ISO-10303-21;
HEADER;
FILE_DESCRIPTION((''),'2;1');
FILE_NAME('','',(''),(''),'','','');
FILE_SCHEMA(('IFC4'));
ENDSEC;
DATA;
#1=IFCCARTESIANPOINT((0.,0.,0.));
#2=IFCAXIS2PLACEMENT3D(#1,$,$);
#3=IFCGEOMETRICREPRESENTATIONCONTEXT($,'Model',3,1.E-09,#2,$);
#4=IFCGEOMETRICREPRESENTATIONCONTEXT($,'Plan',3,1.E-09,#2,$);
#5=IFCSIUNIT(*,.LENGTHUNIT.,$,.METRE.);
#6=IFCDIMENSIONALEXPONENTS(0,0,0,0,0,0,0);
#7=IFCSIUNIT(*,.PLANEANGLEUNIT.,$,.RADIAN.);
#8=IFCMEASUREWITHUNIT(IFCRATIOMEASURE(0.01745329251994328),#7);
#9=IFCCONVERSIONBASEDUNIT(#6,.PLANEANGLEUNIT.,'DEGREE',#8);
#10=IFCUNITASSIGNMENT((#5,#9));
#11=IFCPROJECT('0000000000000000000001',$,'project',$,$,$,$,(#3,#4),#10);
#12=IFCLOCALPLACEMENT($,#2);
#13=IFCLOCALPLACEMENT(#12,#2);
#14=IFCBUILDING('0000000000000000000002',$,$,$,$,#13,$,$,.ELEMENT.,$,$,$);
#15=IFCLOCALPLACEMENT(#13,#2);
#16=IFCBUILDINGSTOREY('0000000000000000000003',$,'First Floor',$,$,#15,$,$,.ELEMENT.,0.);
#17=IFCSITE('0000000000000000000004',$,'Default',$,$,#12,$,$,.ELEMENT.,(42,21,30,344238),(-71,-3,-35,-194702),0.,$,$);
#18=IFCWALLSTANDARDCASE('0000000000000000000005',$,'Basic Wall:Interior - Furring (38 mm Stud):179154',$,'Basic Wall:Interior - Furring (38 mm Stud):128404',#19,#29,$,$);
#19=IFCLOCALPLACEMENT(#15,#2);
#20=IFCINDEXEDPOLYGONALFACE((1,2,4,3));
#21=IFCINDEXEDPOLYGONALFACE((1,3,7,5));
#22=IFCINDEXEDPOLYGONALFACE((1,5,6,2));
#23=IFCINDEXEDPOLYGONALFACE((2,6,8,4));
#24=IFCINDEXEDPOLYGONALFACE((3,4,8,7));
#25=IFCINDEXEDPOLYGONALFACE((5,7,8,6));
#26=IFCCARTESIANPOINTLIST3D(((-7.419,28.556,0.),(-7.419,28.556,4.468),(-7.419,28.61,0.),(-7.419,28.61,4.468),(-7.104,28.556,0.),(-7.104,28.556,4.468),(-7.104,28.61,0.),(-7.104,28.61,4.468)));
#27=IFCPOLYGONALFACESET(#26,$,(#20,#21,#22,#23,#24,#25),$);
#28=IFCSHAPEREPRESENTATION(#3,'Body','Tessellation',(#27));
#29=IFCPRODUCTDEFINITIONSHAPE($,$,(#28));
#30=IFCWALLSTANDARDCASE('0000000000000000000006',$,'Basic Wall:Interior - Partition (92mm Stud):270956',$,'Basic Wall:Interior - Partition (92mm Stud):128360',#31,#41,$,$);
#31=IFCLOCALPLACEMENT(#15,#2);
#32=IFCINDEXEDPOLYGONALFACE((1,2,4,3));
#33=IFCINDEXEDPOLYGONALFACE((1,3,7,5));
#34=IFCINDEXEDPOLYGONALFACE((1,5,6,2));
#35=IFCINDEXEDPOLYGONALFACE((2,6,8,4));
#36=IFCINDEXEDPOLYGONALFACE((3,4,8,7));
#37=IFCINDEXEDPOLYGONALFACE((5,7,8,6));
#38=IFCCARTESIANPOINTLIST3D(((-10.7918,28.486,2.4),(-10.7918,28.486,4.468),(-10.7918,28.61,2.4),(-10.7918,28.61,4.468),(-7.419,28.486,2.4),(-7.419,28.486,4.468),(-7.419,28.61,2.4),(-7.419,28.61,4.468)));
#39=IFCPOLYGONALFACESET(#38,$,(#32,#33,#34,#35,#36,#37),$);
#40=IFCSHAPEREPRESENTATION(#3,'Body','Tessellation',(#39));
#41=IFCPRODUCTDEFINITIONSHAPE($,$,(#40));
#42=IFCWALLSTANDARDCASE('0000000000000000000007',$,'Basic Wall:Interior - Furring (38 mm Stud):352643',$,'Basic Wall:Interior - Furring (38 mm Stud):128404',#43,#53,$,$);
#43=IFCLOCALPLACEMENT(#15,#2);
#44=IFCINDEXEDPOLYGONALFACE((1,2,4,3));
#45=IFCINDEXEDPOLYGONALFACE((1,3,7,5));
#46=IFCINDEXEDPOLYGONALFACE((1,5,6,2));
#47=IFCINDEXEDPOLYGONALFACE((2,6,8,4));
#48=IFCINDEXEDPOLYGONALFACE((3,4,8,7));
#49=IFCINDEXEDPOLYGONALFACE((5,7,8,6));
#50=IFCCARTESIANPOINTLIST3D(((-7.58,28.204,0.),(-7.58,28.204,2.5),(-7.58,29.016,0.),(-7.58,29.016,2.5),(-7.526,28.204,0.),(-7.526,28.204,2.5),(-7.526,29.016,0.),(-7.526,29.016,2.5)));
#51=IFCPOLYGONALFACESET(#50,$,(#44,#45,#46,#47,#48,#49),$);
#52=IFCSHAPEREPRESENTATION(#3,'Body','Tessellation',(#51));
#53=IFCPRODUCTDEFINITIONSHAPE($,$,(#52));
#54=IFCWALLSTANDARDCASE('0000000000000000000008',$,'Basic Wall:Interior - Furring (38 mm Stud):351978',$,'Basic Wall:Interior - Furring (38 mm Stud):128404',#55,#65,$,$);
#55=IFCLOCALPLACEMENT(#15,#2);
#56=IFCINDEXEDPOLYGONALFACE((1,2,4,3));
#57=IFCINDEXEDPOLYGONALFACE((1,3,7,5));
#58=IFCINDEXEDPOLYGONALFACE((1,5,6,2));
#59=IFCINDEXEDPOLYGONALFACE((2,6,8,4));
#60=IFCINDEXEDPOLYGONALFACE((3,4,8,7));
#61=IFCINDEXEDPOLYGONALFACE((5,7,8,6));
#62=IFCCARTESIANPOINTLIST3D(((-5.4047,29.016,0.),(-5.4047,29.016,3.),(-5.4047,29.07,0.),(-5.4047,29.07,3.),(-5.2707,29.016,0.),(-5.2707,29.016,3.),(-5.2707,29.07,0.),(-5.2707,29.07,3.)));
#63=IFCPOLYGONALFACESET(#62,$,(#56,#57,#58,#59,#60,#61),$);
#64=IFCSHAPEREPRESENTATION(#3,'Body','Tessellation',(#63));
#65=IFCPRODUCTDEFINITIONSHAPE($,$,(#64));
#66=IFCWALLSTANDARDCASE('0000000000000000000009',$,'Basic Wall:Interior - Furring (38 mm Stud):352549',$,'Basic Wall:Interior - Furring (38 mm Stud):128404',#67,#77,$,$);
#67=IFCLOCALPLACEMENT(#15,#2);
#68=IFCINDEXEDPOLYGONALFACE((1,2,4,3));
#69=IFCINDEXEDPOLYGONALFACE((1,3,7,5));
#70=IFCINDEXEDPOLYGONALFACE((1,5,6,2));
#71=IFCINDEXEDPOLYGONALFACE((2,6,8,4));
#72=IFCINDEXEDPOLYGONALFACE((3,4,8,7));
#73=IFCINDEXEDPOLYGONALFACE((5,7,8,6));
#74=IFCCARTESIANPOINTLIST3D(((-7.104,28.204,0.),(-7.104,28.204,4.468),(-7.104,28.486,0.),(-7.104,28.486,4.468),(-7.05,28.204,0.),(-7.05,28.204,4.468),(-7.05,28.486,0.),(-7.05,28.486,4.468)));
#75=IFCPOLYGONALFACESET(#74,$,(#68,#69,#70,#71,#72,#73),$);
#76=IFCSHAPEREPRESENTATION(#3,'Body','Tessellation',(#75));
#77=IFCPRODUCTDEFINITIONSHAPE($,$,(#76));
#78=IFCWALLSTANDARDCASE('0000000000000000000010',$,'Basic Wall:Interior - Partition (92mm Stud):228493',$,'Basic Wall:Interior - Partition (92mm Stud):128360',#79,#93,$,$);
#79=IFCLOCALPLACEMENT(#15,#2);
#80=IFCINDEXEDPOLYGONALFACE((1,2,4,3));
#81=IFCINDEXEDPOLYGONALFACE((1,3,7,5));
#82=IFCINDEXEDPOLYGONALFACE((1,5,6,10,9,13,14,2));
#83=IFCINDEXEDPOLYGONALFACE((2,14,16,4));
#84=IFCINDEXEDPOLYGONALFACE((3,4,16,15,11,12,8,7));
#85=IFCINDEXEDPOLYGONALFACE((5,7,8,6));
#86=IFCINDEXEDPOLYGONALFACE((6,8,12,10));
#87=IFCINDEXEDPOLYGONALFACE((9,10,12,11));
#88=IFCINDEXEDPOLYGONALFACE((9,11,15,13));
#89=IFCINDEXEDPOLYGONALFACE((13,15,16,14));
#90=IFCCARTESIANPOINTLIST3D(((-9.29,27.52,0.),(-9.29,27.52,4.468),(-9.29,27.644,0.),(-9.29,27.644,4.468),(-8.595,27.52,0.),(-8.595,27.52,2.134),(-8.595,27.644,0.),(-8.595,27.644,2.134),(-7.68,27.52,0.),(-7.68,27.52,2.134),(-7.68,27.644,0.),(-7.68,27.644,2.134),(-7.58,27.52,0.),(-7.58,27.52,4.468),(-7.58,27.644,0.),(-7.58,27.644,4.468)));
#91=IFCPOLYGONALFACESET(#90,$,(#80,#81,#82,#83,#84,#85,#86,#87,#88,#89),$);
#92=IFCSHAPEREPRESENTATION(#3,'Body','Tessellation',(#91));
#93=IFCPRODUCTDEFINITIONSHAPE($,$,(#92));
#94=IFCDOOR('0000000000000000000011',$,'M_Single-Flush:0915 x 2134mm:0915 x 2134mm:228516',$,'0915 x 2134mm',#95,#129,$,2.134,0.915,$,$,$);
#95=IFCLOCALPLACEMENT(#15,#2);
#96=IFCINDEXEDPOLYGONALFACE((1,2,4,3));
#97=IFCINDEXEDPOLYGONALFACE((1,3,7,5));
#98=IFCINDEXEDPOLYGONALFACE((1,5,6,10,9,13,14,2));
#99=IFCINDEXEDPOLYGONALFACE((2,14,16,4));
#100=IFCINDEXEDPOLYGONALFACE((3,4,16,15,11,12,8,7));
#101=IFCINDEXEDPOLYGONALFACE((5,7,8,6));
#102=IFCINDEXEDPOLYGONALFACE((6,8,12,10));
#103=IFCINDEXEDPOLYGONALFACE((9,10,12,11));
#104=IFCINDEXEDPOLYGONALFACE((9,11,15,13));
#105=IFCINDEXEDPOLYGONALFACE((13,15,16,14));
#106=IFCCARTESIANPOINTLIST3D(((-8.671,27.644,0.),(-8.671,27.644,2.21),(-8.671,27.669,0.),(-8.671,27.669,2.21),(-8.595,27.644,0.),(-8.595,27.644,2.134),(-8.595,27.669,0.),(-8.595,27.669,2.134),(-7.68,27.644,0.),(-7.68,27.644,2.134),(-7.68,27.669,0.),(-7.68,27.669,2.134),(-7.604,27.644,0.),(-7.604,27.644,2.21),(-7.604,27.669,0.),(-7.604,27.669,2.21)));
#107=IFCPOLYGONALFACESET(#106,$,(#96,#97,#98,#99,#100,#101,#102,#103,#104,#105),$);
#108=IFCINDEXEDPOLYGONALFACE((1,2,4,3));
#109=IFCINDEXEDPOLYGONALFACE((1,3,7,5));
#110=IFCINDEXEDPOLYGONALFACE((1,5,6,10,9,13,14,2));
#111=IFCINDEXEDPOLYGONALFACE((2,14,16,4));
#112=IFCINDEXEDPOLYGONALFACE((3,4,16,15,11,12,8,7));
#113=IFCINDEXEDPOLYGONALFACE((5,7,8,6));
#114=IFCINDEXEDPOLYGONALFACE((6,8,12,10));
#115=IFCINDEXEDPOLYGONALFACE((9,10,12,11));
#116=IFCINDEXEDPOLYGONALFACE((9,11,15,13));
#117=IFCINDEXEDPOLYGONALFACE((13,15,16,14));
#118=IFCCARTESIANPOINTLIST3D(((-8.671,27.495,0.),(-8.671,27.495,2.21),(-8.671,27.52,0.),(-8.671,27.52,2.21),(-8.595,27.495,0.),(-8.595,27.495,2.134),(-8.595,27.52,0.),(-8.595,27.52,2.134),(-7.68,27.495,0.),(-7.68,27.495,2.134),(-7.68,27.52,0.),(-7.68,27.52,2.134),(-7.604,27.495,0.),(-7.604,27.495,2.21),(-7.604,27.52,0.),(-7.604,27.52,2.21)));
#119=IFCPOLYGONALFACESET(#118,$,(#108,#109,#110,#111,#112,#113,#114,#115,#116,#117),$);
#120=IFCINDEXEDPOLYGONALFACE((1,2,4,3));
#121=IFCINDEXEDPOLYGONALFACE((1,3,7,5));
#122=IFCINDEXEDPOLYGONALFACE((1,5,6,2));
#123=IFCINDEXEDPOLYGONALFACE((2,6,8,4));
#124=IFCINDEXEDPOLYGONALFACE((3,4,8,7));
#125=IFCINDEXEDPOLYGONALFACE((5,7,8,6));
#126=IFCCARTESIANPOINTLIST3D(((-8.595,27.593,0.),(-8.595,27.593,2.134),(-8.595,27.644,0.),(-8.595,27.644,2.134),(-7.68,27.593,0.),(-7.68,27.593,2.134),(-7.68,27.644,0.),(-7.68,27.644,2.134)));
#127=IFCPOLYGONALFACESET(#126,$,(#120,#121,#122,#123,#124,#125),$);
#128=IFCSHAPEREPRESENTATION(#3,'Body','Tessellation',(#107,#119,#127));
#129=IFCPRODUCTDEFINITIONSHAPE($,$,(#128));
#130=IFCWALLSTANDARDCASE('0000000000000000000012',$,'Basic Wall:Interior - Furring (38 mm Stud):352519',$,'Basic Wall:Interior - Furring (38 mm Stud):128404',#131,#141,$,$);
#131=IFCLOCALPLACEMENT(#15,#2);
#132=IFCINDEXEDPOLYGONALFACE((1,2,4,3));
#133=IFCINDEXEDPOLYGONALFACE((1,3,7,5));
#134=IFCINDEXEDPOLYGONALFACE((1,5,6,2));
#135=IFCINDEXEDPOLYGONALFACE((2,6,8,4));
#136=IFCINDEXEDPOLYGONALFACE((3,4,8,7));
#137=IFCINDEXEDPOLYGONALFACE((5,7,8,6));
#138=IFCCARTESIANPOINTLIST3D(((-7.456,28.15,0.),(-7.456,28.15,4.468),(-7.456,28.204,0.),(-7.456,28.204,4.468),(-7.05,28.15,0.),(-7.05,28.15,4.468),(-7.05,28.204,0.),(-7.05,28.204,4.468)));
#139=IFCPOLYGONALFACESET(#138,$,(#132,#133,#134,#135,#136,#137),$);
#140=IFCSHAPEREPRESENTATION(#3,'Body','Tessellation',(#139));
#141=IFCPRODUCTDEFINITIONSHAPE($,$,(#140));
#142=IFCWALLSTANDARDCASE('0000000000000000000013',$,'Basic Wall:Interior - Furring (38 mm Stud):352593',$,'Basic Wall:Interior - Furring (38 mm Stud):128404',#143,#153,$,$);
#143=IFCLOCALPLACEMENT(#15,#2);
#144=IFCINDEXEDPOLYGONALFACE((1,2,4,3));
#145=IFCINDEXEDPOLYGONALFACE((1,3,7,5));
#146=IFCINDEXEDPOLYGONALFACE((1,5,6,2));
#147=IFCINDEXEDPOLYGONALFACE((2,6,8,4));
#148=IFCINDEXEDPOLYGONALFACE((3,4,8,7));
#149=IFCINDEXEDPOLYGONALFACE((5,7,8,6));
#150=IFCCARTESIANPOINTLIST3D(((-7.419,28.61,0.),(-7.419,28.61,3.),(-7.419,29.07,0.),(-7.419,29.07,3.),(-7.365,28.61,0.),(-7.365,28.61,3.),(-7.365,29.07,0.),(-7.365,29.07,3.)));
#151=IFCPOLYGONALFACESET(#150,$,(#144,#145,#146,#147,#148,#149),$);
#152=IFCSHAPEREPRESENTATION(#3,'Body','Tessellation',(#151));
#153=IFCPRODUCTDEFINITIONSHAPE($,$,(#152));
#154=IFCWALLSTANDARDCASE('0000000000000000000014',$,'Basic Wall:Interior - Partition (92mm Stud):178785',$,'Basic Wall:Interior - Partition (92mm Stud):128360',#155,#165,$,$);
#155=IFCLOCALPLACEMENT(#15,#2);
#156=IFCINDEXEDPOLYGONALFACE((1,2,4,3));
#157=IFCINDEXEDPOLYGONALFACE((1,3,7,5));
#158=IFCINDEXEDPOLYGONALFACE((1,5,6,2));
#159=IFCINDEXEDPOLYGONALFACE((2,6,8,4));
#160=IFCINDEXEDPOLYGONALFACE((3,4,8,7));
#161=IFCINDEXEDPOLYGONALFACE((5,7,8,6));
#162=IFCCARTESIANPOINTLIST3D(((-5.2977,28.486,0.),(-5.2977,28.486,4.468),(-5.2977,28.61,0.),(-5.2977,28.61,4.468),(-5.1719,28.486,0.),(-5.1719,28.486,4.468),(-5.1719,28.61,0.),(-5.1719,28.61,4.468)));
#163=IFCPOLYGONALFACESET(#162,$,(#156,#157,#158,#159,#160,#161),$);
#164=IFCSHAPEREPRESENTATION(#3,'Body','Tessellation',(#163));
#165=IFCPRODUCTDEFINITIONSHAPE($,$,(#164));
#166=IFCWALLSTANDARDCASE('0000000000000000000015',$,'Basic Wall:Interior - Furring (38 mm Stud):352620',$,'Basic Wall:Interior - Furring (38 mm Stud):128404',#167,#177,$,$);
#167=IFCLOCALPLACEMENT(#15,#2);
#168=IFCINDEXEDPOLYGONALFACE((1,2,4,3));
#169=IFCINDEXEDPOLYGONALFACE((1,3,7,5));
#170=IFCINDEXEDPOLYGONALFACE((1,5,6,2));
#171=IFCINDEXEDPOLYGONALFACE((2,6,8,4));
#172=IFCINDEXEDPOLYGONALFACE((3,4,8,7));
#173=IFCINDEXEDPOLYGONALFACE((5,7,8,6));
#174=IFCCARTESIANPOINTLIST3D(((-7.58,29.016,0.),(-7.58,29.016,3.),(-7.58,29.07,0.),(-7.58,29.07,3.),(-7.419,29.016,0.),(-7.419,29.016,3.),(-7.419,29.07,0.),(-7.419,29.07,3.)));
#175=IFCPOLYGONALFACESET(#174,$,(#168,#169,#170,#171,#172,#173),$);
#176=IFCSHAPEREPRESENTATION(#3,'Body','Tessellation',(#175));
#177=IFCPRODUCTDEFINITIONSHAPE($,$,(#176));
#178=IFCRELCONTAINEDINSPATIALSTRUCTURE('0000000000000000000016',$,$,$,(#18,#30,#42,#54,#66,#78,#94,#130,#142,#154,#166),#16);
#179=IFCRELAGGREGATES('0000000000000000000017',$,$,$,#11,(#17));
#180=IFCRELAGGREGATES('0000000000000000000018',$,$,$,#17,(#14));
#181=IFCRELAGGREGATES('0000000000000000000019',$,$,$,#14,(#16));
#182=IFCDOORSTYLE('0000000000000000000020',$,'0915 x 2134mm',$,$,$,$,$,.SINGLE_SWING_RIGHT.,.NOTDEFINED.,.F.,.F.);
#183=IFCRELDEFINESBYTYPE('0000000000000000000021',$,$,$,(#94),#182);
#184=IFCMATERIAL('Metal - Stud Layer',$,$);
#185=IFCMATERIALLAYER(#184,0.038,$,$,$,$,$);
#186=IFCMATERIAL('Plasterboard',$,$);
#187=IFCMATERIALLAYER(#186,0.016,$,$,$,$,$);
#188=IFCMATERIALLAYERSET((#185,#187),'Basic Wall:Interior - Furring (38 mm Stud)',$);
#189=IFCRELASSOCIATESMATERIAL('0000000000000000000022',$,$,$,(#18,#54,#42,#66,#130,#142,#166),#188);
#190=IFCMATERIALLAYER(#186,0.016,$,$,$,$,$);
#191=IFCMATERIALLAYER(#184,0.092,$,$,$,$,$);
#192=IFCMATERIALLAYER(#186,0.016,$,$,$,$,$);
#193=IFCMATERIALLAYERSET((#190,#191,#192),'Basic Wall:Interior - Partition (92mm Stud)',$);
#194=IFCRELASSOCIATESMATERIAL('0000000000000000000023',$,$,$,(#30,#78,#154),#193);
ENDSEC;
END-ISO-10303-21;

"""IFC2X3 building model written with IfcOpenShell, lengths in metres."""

from ifc_helpers import new_model, entity, si_unit, converted_unit, frame, frame_2d, origin, origin_2d_with_axis, place, context, project, spatial, polyline, rectangle, outline, extrude, source, transform, mapped, material, layer, layer_set, layer_usage, type_object, type_shapes, element, fill, save


model = new_model("IFC2X3")

# Units and contexts
model_context = context("Model", 3, precision=1e-09, world=origin())
plan_context = context("Plan", 3, precision=1e-09, world=origin())
ifc_project = project(units=[si_unit("LENGTHUNIT", "METRE"), converted_unit("PLANEANGLEUNIT", "DEGREE", entity("IfcRatioMeasure", 0.01745329251994328), si_unit("PLANEANGLEUNIT", "RADIAN"), dimensions=[0, 0, 0, 0, 0, 0, 0])], contexts=[model_context, plan_context])

# Site, building, storey
site_placement = place(None, origin())
site = spatial("IfcSite", under=ifc_project, at=site_placement, Name="Default", CompositionType="ELEMENT", RefLatitude=(42, 21, 30, 344238), RefLongitude=(-71, -3, -35, -194702), RefElevation=0.0)
building_placement = place(site_placement, origin())
building = spatial("IfcBuilding", under=site, at=building_placement, CompositionType="ELEMENT")
storey_placement = place(building_placement, origin())
storey = spatial("IfcBuildingStorey", under=building, at=storey_placement, Name="First Floor", CompositionType="ELEMENT", Elevation=0.0)

# Shared definitions
ifc_material_1 = material(Name="Plasterboard")
ifc_layer_1 = layer(ifc_material_1, 0.016)
ifc_material_2 = material(Name="Metal - Stud Layer")
ifc_layer_2 = layer(ifc_material_2, 0.092)
ifc_layer_3 = layer(ifc_material_1, 0.016)
ifc_layer_set_1 = layer_set([ifc_layer_1, ifc_layer_2, ifc_layer_3], Name="Basic Wall:Interior - Partition (92mm Stud)")
ifc_layer_usage_1 = layer_usage(ifc_layer_set_1, "AXIS2", "NEGATIVE", 0.062)
door_style_1 = type_object("IfcDoorStyle", Name="0915 x 2134mm", ConstructionType="NOTDEFINED", OperationType="SINGLE_SWING_RIGHT", ParameterTakesPrecedence=False, Sizeable=False)
shared_shape_1 = source(origin(), model_context, "Body", "SweptSolid", [
    extrude(outline(polyline([(-0.5335, -1.124), (0.5335, -1.124), (0.5335, 1.086), (0.4575, 1.086), (0.4575, -1.048), (-0.4575, -1.048), (-0.4575, 1.086), (-0.5335, 1.086), (-0.5335, -1.124)])), frame((0.4575, 0.124, 1.086), z_axis=(0.0, 1.0, 0.0), x_axis=(1.0, 0.0, 0.0)), (0.0, 0.0, 1.0), 0.025),
    extrude(outline(polyline([(-1.124, -0.5335), (1.086, -0.5335), (1.086, -0.4575), (-1.048, -0.4575), (-1.048, 0.4575), (1.086, 0.4575), (1.086, 0.5335), (-1.124, 0.5335), (-1.124, -0.5335)])), frame((0.4575, -0.025, 1.086), z_axis=(0.0, 1.0, 0.0), x_axis=(0.0, 0.0, -1.0)), (0.0, 0.0, 1.0), 0.025),
    extrude(rectangle(XDim=0.051, YDim=0.915, at=origin_2d_with_axis()), frame((0.4575, 0.0985, 0.0), z_axis=(0.0, 0.0, 1.0), x_axis=(0.0, 1.0, 0.0)), (0.0, 0.0, 1.0), 2.134),
])
type_shapes(door_style_1, [shared_shape_1])

# Walls
ifc_layer_4 = layer(ifc_material_2, 0.038)
ifc_layer_5 = layer(ifc_material_1, 0.016)
ifc_layer_set_2 = layer_set([ifc_layer_4, ifc_layer_5], Name="Basic Wall:Interior - Furring (38 mm Stud)")
ifc_layer_usage_2 = layer_usage(ifc_layer_set_2, "AXIS2", "POSITIVE", -0.027)
wall_1_placement = place(storey_placement, frame((-7.419, 28.583, 0.0)))
element("IfcWallStandardCase", 1, at=wall_1_placement, inside=storey, material=ifc_layer_usage_2, Name="Basic Wall:Interior - Furring (38 mm Stud):179154", ObjectType="Basic Wall:Interior - Furring (38 mm Stud):128404", context=model_context, shape_type="SweptSolid", body=[
    extrude(rectangle(XDim=0.315, YDim=0.054, at=frame_2d((0.1575, 0.0), x_axis=(-1.0, 0.0))), origin(), (0.0, 0.0, 1.0), 4.468),
])
wall_2_placement = place(storey_placement, frame((-7.392, 28.548, 2.4), z_axis=(0.0, 0.0, 1.0), x_axis=(-1.0, 0.0, 0.0)))
element("IfcWallStandardCase", 2, at=wall_2_placement, inside=storey, material=ifc_layer_usage_1, Name="Basic Wall:Interior - Partition (92mm Stud):270956", ObjectType="Basic Wall:Interior - Partition (92mm Stud):128360", context=model_context, shape_type="SweptSolid", body=[
    extrude(rectangle(XDim=3.3729, YDim=0.124, at=frame_2d((1.7134, 0.0), x_axis=(-1.0, 0.0))), origin(), (0.0, 0.0, 1.0), 2.068),
])
ifc_layer_usage_3 = layer_usage(ifc_layer_set_2, "AXIS2", "NEGATIVE", 0.027)
wall_3_placement = place(storey_placement, frame((-7.553, 29.016, 0.0), z_axis=(0.0, 0.0, 1.0), x_axis=(0.0, -1.0, 0.0)))
element("IfcWallStandardCase", 3, at=wall_3_placement, inside=storey, material=ifc_layer_usage_3, Name="Basic Wall:Interior - Furring (38 mm Stud):352643", ObjectType="Basic Wall:Interior - Furring (38 mm Stud):128404", context=model_context, shape_type="SweptSolid", body=[
    extrude(rectangle(XDim=0.812, YDim=0.054, at=frame_2d((0.406, 0.0), x_axis=(-1.0, 0.0))), origin(), (0.0, 0.0, 1.0), 2.5),
])
wall_4_placement = place(storey_placement, frame((-5.4047, 29.043, 0.0)))
element("IfcWallStandardCase", 4, at=wall_4_placement, inside=storey, material=ifc_layer_usage_2, Name="Basic Wall:Interior - Furring (38 mm Stud):351978", ObjectType="Basic Wall:Interior - Furring (38 mm Stud):128404", context=model_context, shape_type="SweptSolid", body=[
    extrude(rectangle(XDim=0.134, YDim=0.054, at=frame_2d((0.067, 0.0), x_axis=(-1.0, 0.0))), origin(), (0.0, 0.0, 1.0), 3.0),
])
wall_5_placement = place(storey_placement, frame((-7.077, 28.204, 0.0), z_axis=(0.0, 0.0, 1.0), x_axis=(0.0, 1.0, 0.0)))
element("IfcWallStandardCase", 5, at=wall_5_placement, inside=storey, material=ifc_layer_usage_3, Name="Basic Wall:Interior - Furring (38 mm Stud):352549", ObjectType="Basic Wall:Interior - Furring (38 mm Stud):128404", context=model_context, shape_type="SweptSolid", body=[
    extrude(rectangle(XDim=0.282, YDim=0.054, at=frame_2d((0.141, 0.0), x_axis=(-1.0, 0.0))), origin(), (0.0, 0.0, 1.0), 4.468),
])

# Wall, opening, door
wall_6_placement = place(storey_placement, frame((-7.58, 27.582, 0.0), z_axis=(0.0, 0.0, 1.0), x_axis=(-1.0, 0.0, 0.0)))
wall_6 = element("IfcWallStandardCase", 6, at=wall_6_placement, inside=storey, material=ifc_layer_usage_1, Name="Basic Wall:Interior - Partition (92mm Stud):228493", ObjectType="Basic Wall:Interior - Partition (92mm Stud):128360", context=model_context, shape_type="SweptSolid", body=[
    extrude(rectangle(XDim=1.71, YDim=0.124, at=frame_2d((0.855, 0.0), x_axis=(-1.0, 0.0))), origin(), (0.0, 0.0, 1.0), 4.468),
])
opening_1_placement = place(wall_6_placement, frame((1.015, 0.062, 0.0)))
opening_1 = element("IfcOpeningElement", 7, at=opening_1_placement, cuts=wall_6, ObjectType="Opening", context=model_context, shape_type="SweptSolid", body=[
    extrude(rectangle(XDim=0.915, YDim=2.134, at=frame_2d((1.067, 0.4575), x_axis=(0.0, 1.0))), frame((0.0, 0.0, 0.0), z_axis=(0.0, -1.0, 0.0), x_axis=(0.0, 0.0, 1.0)), (0.0, 0.0, 1.0), 0.124),
])
door_1_placement = place(opening_1_placement, frame((0.0, 0.0, 0.0), z_axis=(0.0, 0.0, 1.0), x_axis=(-1.0, 0.0, 0.0)))
door_1 = element("IfcDoor", 8, at=door_1_placement, inside=storey, type_object=door_style_1, Name="M_Single-Flush:0915 x 2134mm:0915 x 2134mm:228516", ObjectType="0915 x 2134mm", OverallHeight=2.134, OverallWidth=0.915, context=model_context, shape_type="MappedRepresentation", body=[
    mapped(shared_shape_1, transform((0.0, 0.0, 0.0), scale=1.0)),
])
fill(opening_1, door_1)

# Walls
wall_7_placement = place(storey_placement, frame((-7.456, 28.177, 0.0)))
element("IfcWallStandardCase", 9, at=wall_7_placement, inside=storey, material=ifc_layer_usage_3, Name="Basic Wall:Interior - Furring (38 mm Stud):352519", ObjectType="Basic Wall:Interior - Furring (38 mm Stud):128404", context=model_context, shape_type="SweptSolid", body=[
    extrude(rectangle(XDim=0.406, YDim=0.054, at=frame_2d((0.203, 0.0), x_axis=(-1.0, 0.0))), origin(), (0.0, 0.0, 1.0), 4.468),
])
wall_8_placement = place(storey_placement, frame((-7.392, 28.61, 0.0), z_axis=(0.0, 0.0, 1.0), x_axis=(0.0, 1.0, 0.0)))
element("IfcWallStandardCase", 10, at=wall_8_placement, inside=storey, material=ifc_layer_usage_3, Name="Basic Wall:Interior - Furring (38 mm Stud):352593", ObjectType="Basic Wall:Interior - Furring (38 mm Stud):128404", context=model_context, shape_type="SweptSolid", body=[
    extrude(rectangle(XDim=0.46, YDim=0.054, at=frame_2d((0.23, 0.0), x_axis=(-1.0, 0.0))), origin(), (0.0, 0.0, 1.0), 3.0),
])
wall_9_placement = place(storey_placement, frame((-5.2977, 28.548, 0.0)))
element("IfcWallStandardCase", 11, at=wall_9_placement, inside=storey, material=ifc_layer_usage_1, Name="Basic Wall:Interior - Partition (92mm Stud):178785", ObjectType="Basic Wall:Interior - Partition (92mm Stud):128360", context=model_context, shape_type="SweptSolid", body=[
    extrude(rectangle(XDim=0.1259, YDim=0.124, at=frame_2d((0.0629, 0.0), x_axis=(-1.0, 0.0))), origin(), (0.0, 0.0, 1.0), 4.468),
])
wall_10_placement = place(storey_placement, frame((-7.419, 29.043, 0.0), z_axis=(0.0, 0.0, 1.0), x_axis=(-1.0, 0.0, 0.0)))
element("IfcWallStandardCase", 12, at=wall_10_placement, inside=storey, material=ifc_layer_usage_3, Name="Basic Wall:Interior - Furring (38 mm Stud):352620", ObjectType="Basic Wall:Interior - Furring (38 mm Stud):128404", context=model_context, shape_type="SweptSolid", body=[
    extrude(rectangle(XDim=0.161, YDim=0.054, at=frame_2d((0.0805, 0.0), x_axis=(-1.0, 0.0))), origin(), (0.0, 0.0, 1.0), 3.0),
])

save(model, "model.ifc")
